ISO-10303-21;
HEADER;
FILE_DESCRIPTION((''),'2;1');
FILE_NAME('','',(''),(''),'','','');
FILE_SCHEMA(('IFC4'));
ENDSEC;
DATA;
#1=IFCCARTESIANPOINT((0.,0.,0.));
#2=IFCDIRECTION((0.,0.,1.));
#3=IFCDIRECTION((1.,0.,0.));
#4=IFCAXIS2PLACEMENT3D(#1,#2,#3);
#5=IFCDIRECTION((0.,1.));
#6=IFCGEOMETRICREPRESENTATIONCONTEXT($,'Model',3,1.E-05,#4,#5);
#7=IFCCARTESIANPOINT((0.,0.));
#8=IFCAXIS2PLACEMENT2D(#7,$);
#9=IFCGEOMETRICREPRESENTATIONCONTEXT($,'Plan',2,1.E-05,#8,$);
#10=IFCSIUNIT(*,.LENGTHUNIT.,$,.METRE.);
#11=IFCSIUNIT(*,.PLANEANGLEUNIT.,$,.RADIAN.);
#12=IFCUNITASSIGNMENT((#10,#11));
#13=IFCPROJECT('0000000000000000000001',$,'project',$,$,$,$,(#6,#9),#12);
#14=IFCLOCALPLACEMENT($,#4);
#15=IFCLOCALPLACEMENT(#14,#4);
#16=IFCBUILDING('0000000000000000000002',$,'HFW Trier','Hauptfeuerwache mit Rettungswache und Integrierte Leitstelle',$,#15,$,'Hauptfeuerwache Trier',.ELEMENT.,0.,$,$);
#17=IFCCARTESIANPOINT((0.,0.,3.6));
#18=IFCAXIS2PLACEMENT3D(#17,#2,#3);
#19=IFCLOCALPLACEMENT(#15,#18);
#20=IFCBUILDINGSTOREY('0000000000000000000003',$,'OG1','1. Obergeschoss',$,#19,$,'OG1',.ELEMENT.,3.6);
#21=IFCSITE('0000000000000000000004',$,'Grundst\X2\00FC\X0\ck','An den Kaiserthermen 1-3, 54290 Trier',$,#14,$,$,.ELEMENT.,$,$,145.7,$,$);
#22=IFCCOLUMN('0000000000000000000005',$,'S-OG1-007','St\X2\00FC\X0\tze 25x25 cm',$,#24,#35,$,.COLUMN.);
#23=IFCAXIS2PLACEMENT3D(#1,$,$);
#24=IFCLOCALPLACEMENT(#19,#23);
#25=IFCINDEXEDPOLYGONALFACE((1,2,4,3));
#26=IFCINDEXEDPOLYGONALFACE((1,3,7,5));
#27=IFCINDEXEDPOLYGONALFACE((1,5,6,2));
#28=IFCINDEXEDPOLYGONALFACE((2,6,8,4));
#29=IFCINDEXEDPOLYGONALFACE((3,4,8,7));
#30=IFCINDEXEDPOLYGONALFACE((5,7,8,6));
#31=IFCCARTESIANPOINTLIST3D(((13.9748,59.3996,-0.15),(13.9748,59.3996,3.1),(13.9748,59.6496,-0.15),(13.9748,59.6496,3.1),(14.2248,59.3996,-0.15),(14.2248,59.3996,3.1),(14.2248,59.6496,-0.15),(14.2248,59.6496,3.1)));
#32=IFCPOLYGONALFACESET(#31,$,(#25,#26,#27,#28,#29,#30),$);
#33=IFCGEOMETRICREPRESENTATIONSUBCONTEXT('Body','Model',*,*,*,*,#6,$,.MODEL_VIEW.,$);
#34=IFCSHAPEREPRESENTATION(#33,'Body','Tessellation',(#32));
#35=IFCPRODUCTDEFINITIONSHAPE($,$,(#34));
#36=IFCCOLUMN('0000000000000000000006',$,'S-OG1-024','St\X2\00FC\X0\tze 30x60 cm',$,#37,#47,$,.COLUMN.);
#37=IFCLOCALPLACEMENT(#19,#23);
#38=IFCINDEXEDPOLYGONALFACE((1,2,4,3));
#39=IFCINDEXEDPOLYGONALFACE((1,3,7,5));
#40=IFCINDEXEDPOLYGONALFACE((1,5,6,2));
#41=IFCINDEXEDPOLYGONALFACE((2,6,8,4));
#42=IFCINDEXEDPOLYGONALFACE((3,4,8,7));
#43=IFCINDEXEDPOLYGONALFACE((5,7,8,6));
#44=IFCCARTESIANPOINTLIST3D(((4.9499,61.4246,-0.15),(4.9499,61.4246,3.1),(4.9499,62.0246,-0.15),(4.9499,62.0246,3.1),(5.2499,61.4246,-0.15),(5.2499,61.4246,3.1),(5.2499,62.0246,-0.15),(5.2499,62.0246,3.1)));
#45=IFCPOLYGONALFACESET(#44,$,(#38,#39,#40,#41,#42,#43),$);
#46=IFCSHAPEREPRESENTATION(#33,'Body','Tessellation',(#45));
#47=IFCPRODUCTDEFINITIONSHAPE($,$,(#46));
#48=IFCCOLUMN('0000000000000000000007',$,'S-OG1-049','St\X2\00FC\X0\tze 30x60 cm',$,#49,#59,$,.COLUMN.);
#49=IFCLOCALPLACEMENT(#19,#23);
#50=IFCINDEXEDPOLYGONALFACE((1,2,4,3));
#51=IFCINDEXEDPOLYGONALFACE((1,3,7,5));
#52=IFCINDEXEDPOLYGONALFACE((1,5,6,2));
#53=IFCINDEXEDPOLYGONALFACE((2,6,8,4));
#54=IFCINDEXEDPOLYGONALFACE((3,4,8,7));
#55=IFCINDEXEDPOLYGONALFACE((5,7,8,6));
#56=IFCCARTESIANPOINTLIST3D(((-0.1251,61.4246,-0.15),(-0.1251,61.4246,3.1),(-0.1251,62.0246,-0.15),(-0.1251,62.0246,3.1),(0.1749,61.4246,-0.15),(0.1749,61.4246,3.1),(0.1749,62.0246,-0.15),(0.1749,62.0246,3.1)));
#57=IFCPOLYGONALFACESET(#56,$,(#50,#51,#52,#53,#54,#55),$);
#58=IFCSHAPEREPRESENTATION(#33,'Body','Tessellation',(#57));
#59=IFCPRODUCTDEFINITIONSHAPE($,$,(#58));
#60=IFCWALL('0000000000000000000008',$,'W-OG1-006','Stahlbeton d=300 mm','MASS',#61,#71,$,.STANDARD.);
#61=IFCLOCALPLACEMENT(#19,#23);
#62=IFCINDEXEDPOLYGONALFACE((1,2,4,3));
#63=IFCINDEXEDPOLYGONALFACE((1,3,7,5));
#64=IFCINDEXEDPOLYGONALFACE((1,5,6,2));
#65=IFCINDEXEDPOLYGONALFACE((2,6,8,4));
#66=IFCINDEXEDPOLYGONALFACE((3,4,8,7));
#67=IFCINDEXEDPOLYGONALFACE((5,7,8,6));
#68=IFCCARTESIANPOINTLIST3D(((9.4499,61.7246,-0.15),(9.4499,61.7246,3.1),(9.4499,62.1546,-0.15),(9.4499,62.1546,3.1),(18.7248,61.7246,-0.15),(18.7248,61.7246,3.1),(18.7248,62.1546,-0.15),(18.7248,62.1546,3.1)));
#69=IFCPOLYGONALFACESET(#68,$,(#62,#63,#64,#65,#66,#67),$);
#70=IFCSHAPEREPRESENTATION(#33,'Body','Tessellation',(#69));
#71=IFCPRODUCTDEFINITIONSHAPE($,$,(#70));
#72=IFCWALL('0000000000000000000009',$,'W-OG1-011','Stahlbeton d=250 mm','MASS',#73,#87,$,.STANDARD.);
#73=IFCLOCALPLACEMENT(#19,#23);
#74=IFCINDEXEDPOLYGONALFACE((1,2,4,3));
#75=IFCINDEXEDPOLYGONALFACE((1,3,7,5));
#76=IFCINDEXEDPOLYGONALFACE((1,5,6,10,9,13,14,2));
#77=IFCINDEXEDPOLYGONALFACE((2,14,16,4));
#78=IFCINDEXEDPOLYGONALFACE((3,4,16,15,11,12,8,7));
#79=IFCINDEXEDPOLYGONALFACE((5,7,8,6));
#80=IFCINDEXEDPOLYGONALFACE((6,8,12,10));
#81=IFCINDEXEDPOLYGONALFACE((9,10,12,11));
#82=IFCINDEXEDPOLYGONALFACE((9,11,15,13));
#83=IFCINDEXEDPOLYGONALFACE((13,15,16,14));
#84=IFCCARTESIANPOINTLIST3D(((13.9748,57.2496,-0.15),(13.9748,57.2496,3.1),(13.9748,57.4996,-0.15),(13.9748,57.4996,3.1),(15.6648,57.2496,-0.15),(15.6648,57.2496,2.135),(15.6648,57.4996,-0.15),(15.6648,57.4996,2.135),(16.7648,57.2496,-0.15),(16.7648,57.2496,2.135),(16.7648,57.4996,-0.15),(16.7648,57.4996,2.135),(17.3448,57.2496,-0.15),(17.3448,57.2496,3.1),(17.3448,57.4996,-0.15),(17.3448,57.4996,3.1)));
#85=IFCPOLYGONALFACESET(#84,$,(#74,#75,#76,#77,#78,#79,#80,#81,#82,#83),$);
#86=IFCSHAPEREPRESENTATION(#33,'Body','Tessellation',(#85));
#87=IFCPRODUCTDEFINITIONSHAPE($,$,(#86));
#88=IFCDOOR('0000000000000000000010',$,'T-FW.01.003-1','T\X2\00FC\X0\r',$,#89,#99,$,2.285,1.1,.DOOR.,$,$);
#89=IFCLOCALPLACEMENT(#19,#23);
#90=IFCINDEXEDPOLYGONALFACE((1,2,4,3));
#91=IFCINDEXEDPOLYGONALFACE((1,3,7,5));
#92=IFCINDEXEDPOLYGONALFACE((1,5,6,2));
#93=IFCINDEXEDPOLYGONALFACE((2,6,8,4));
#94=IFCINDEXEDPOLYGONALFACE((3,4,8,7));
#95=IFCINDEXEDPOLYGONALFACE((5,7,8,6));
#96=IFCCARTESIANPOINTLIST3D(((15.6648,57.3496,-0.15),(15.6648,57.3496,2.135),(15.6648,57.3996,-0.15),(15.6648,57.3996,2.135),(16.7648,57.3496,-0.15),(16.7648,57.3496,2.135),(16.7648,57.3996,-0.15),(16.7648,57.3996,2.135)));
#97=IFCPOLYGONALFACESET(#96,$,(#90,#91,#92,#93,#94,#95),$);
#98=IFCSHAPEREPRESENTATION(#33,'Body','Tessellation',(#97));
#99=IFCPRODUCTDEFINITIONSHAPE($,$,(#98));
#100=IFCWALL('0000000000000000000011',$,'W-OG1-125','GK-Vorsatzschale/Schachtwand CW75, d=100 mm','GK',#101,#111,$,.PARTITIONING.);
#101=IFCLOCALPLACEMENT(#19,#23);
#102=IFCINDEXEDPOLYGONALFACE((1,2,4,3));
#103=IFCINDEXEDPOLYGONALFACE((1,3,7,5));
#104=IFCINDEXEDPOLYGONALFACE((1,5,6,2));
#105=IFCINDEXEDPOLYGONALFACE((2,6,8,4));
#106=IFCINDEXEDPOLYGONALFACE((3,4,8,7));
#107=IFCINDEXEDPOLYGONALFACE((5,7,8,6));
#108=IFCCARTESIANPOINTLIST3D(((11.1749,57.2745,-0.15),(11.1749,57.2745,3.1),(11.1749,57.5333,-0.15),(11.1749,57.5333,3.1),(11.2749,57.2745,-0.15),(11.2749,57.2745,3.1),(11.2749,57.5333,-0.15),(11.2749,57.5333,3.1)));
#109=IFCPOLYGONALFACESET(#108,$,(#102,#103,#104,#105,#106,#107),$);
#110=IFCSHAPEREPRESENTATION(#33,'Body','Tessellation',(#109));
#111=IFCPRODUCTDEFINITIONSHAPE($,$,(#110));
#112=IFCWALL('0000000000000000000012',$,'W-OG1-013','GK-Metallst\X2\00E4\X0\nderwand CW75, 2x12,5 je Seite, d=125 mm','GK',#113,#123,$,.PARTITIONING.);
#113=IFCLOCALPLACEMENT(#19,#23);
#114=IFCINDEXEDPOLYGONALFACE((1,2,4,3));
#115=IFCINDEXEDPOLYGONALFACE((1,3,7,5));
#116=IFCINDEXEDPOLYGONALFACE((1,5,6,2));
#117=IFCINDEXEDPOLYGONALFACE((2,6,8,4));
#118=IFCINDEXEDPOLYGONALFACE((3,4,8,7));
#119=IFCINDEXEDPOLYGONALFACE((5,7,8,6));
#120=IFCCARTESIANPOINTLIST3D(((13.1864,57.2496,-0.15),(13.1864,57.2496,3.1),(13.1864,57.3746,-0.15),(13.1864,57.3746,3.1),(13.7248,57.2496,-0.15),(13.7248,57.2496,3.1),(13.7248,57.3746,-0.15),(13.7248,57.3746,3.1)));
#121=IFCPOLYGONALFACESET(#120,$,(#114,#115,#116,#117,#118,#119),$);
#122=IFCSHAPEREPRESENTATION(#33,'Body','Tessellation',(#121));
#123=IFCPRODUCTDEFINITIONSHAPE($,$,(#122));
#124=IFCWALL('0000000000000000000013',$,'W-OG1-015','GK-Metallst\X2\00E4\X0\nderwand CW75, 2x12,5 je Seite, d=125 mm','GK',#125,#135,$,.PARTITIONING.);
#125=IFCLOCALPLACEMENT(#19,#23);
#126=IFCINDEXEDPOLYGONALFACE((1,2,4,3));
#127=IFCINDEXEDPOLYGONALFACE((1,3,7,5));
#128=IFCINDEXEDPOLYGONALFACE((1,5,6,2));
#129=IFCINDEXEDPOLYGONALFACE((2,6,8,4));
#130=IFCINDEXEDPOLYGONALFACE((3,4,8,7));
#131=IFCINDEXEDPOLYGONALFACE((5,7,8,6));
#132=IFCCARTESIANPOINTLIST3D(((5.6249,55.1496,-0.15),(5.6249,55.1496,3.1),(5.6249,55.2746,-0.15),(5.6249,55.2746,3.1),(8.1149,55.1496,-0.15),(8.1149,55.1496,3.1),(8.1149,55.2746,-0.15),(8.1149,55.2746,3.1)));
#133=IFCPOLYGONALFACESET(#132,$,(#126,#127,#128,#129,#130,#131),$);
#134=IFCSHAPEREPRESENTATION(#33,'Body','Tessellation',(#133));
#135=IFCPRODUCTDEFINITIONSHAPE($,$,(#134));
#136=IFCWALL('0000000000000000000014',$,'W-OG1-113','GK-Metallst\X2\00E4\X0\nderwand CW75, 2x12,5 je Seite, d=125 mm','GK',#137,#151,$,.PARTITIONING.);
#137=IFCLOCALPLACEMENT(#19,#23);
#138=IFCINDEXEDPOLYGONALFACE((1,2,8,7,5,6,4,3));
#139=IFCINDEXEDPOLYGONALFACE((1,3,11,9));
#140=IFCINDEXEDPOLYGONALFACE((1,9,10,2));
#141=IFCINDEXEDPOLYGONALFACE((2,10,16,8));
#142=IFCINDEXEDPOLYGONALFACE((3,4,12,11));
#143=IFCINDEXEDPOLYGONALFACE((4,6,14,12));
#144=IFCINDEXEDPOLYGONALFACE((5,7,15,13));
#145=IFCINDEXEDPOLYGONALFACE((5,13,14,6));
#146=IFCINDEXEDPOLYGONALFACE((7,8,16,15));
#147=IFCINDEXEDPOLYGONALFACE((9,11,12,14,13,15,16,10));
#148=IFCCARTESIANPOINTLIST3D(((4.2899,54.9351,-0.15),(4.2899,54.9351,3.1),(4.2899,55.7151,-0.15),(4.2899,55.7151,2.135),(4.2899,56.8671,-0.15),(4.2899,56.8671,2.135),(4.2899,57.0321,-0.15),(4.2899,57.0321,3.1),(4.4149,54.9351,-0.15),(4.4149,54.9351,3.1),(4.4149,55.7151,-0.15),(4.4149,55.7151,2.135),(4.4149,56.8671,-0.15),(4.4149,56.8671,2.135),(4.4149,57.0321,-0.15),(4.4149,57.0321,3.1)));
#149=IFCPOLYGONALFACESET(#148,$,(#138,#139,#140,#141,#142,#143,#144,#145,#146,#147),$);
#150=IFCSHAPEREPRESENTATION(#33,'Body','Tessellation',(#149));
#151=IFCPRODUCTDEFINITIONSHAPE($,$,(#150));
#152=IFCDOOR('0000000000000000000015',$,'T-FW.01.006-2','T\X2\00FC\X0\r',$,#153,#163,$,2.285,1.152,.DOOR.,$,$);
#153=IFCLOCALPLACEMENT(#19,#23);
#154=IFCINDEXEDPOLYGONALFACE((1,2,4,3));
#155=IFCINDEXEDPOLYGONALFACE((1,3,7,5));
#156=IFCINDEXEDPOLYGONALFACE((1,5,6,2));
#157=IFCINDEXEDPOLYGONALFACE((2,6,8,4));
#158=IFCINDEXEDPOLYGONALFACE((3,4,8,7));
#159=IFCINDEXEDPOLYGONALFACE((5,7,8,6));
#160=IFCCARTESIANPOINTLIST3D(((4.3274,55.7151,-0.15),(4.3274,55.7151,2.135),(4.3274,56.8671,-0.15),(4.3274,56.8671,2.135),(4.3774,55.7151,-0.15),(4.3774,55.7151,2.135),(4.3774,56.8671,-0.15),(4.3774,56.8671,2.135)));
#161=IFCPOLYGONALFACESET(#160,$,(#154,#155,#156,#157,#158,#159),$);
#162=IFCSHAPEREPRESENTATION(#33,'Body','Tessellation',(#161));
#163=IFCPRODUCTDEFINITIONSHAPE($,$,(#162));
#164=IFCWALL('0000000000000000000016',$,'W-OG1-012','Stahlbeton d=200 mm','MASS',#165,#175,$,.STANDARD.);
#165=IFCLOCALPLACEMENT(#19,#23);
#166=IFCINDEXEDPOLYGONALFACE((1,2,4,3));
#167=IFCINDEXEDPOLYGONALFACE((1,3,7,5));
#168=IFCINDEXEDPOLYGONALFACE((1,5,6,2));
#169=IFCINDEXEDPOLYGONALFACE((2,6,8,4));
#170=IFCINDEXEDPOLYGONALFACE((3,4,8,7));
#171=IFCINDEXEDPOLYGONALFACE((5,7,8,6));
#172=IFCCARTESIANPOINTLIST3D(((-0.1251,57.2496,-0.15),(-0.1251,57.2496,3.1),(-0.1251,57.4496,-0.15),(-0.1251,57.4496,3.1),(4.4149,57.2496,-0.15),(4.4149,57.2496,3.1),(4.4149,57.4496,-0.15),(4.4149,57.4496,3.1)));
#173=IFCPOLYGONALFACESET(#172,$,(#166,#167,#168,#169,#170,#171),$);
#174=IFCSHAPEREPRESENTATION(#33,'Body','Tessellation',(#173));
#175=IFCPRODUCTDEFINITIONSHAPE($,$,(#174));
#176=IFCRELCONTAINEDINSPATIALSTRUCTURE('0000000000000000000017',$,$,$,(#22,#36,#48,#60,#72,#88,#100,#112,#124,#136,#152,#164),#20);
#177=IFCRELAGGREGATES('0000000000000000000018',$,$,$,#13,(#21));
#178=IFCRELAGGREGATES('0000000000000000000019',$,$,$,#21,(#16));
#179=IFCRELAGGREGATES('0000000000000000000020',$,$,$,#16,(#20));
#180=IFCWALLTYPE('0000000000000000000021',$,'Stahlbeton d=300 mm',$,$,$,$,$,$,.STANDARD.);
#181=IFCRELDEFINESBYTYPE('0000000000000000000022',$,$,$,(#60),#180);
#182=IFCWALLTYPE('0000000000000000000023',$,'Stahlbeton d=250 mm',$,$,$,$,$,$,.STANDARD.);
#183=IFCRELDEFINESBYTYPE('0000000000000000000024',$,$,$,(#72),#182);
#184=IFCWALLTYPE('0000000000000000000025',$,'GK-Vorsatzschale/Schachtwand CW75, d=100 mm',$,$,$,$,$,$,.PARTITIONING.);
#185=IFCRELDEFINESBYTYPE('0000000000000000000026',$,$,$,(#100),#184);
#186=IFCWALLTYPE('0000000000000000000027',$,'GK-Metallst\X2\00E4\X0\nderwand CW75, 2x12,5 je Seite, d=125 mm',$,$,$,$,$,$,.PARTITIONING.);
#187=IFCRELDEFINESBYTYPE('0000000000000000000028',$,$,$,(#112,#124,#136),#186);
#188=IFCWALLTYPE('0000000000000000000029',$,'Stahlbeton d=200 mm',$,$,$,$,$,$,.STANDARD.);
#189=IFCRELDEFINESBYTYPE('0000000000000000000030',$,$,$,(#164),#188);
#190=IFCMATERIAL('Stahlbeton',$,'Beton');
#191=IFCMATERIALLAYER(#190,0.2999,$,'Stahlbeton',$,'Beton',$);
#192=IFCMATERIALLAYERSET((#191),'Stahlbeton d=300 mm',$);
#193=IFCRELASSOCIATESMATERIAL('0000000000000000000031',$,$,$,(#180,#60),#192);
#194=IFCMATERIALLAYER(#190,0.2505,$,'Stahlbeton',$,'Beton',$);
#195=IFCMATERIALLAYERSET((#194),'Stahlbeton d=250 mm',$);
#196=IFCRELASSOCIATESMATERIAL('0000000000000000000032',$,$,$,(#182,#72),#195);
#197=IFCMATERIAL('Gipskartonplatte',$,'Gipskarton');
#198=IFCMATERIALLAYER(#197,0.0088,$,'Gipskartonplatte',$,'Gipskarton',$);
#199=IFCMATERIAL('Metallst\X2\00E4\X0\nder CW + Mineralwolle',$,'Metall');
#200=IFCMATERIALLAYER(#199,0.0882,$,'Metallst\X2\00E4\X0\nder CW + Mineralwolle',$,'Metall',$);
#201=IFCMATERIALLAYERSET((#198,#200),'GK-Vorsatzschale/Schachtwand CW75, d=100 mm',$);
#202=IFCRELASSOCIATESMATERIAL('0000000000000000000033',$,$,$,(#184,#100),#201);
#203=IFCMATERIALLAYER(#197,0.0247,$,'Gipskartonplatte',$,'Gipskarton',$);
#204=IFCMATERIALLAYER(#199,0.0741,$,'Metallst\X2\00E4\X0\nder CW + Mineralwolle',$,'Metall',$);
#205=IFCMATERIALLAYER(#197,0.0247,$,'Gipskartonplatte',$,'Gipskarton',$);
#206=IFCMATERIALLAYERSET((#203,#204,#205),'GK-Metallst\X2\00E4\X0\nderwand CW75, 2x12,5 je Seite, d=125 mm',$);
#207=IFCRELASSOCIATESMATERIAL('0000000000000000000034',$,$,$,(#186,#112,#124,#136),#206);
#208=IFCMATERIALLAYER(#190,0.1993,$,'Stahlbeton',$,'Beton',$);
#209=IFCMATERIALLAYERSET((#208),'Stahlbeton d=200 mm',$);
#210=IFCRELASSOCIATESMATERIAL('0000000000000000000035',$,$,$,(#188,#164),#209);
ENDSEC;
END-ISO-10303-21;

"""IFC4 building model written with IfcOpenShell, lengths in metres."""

from ifc_helpers import new_model, si_unit, direction, frame, frame_2d, origin_with_axes, origin_2d, place, context, subcontext, project, spatial, rectangle, extrude, material, layer, layer_set, layer_usage, type_object, element, fill, save


model = new_model("IFC4")

# Units and contexts
model_context = context("Model", 3, precision=1e-05, world=origin_with_axes(), true_north=direction((0.0, 1.0)))
plan_context = context("Plan", 2, precision=1e-05, world=origin_2d())
body_context = subcontext(model_context, "Body", "Model", "MODEL_VIEW")
ifc_project = project(units=[si_unit("LENGTHUNIT", "METRE"), si_unit("PLANEANGLEUNIT", "RADIAN")], contexts=[model_context, plan_context])

# Site, building, storey
site_placement = place(None, origin_with_axes())
site = spatial("IfcSite", under=ifc_project, at=site_placement, Name="Grundstück", Description="An den Kaiserthermen 1-3, 54290 Trier", CompositionType="ELEMENT", RefElevation=145.7)
building_placement = place(site_placement, origin_with_axes())
building = spatial("IfcBuilding", under=site, at=building_placement, Name="HFW Trier", Description="Hauptfeuerwache mit Rettungswache und Integrierte Leitstelle", LongName="Hauptfeuerwache Trier", CompositionType="ELEMENT", ElevationOfRefHeight=0.0)
storey_placement = place(building_placement, frame((0.0, 0.0, 3.6), z_axis=(0.0, 0.0, 1.0), x_axis=(1.0, 0.0, 0.0)))
storey = spatial("IfcBuildingStorey", under=building, at=storey_placement, Name="OG1", Description="1. Obergeschoss", LongName="OG1", CompositionType="ELEMENT", Elevation=3.6)

# Columns
column_placement = place(storey_placement, frame((13.9748, 59.5246, -0.15), z_axis=(0.0, 0.0, 1.0), x_axis=(1.0, 0.0, 0.0)))
element("IfcColumn", 1, at=column_placement, inside=storey, Name="S-OG1-007", Description="Stütze 25x25 cm", PredefinedType="COLUMN", context=body_context, shape_type="SweptSolid", body=[
    extrude(rectangle(XDim=0.25, YDim=0.25, at=frame_2d((0.125, 0.0))), origin_with_axes(), (0.0, 0.0, 1.0), 3.25),
])
for number, where, z_axis, x_axis, name in (
    (2, (4.9499, 61.7246, -0.15), (0.0, 0.0, 1.0), (1.0, 0.0, 0.0), "S-OG1-024"),
    (3, (-0.1251, 61.7246, -0.15), (0.0, 0.0, 1.0), (1.0, 0.0, 0.0), "S-OG1-049"),
):
    element("IfcColumn", number, at=place(storey_placement, frame(where, z_axis=z_axis, x_axis=x_axis)), inside=storey, Name=name, Description="Stütze 30x60 cm", PredefinedType="COLUMN", context=body_context, shape_type="SweptSolid", body=[
        extrude(rectangle(XDim=0.3, YDim=0.6, at=frame_2d((0.15, 0.0))), origin_with_axes(), (0.0, 0.0, 1.0), 3.25),
    ])

# Wall
ifc_material_1 = material(Name="Stahlbeton", Category="Beton")
ifc_layer_1 = layer(ifc_material_1, 0.2999, Name="Stahlbeton", Category="Beton")
ifc_layer_set_1 = layer_set([ifc_layer_1], Name="Stahlbeton d=300 mm")
ifc_layer_usage_1 = layer_usage(ifc_layer_set_1, "AXIS2", "POSITIVE", -0.215)
wall_type_1 = type_object("IfcWallType", Name="Stahlbeton d=300 mm", PredefinedType="STANDARD", material=ifc_layer_set_1)
wall_1_placement = place(storey_placement, frame((9.4499, 61.9396, -0.15), z_axis=(0.0, 0.0, 1.0), x_axis=(1.0, 0.0, 0.0)))
element("IfcWall", 4, at=wall_1_placement, inside=storey, type_object=wall_type_1, material=ifc_layer_usage_1, Name="W-OG1-006", Description="Stahlbeton d=300 mm", ObjectType="MASS", PredefinedType="STANDARD", context=body_context, shape_type="SweptSolid", body=[
    extrude(rectangle(XDim=9.2749, YDim=0.43, at=frame_2d((4.6374, 0.0))), origin_with_axes(), (0.0, 0.0, 1.0), 3.25),
])

# Wall, opening, door
ifc_layer_2 = layer(ifc_material_1, 0.2505, Name="Stahlbeton", Category="Beton")
ifc_layer_set_2 = layer_set([ifc_layer_2], Name="Stahlbeton d=250 mm")
ifc_layer_usage_2 = layer_usage(ifc_layer_set_2, "AXIS2", "POSITIVE", -0.125)
wall_type_2 = type_object("IfcWallType", Name="Stahlbeton d=250 mm", PredefinedType="STANDARD", material=ifc_layer_set_2)
wall_2_placement = place(storey_placement, frame((13.9748, 57.3746, -0.15), z_axis=(0.0, 0.0, 1.0), x_axis=(1.0, 0.0, 0.0)))
wall_2 = element("IfcWall", 5, at=wall_2_placement, inside=storey, type_object=wall_type_2, material=ifc_layer_usage_2, Name="W-OG1-011", Description="Stahlbeton d=250 mm", ObjectType="MASS", PredefinedType="STANDARD", context=body_context, shape_type="SweptSolid", body=[
    extrude(rectangle(XDim=3.37, YDim=0.25, at=frame_2d((1.685, 0.0))), origin_with_axes(), (0.0, 0.0, 1.0), 3.25),
])
opening_1_placement = place(wall_2_placement, frame((1.69, 0.0, 0.0), z_axis=(0.0, 0.0, 1.0), x_axis=(1.0, 0.0, 0.0)))
opening_1 = element("IfcOpeningElement", 6, at=opening_1_placement, cuts=wall_2, PredefinedType="OPENING", context=body_context, shape_type="SweptSolid", body=[
    extrude(rectangle(XDim=1.1, YDim=0.35, at=frame_2d((0.55, 0.0))), origin_with_axes(), (0.0, 0.0, 1.0), 2.285),
])
door_1_placement = place(wall_2_placement, frame((1.69, 0.0, 0.0), z_axis=(0.0, 0.0, 1.0), x_axis=(1.0, 0.0, 0.0)))
door_1 = element("IfcDoor", 7, at=door_1_placement, inside=storey, Name="T-FW.01.003-1", Description="Tür", OverallHeight=2.285, OverallWidth=1.1, PredefinedType="DOOR", context=body_context, shape_type="SweptSolid", body=[
    extrude(rectangle(XDim=1.1, YDim=0.05, at=frame_2d((0.55, 0.0))), origin_with_axes(), (0.0, 0.0, 1.0), 2.285),
])
fill(opening_1, door_1)

# Walls
ifc_material_2 = material(Name="Gipskartonplatte", Category="Gipskarton")
ifc_layer_3 = layer(ifc_material_2, 0.0088, Name="Gipskartonplatte", Category="Gipskarton")
ifc_material_3 = material(Name="Metallständer CW + Mineralwolle", Category="Metall")
ifc_layer_4 = layer(ifc_material_3, 0.0882, Name="Metallständer CW + Mineralwolle", Category="Metall")
ifc_layer_set_3 = layer_set([ifc_layer_3, ifc_layer_4], Name="GK-Vorsatzschale/Schachtwand CW75, d=100 mm")
ifc_layer_usage_3 = layer_usage(ifc_layer_set_3, "AXIS2", "POSITIVE", -0.05)
wall_type_3 = type_object("IfcWallType", Name="GK-Vorsatzschale/Schachtwand CW75, d=100 mm", PredefinedType="PARTITIONING", material=ifc_layer_set_3)
wall_3_placement = place(storey_placement, frame((11.2249, 57.5333, -0.15), z_axis=(0.0, 0.0, 1.0), x_axis=(0.0, -1.0, 0.0)))
element("IfcWall", 8, at=wall_3_placement, inside=storey, type_object=wall_type_3, material=ifc_layer_usage_3, Name="W-OG1-125", Description="GK-Vorsatzschale/Schachtwand CW75, d=100 mm", ObjectType="GK", PredefinedType="PARTITIONING", context=body_context, shape_type="SweptSolid", body=[
    extrude(rectangle(XDim=0.2588, YDim=0.1, at=frame_2d((0.1294, 0.0))), origin_with_axes(), (0.0, 0.0, 1.0), 3.25),
])
ifc_layer_5 = layer(ifc_material_2, 0.0247, Name="Gipskartonplatte", Category="Gipskarton")
ifc_layer_6 = layer(ifc_material_3, 0.0741, Name="Metallständer CW + Mineralwolle", Category="Metall")
ifc_layer_7 = layer(ifc_material_2, 0.0247, Name="Gipskartonplatte", Category="Gipskarton")
ifc_layer_set_4 = layer_set([ifc_layer_5, ifc_layer_6, ifc_layer_7], Name="GK-Metallständerwand CW75, 2x12,5 je Seite, d=125 mm")
ifc_layer_usage_4 = layer_usage(ifc_layer_set_4, "AXIS2", "POSITIVE", -0.0625)
wall_type_4 = type_object("IfcWallType", Name="GK-Metallständerwand CW75, 2x12,5 je Seite, d=125 mm", PredefinedType="PARTITIONING", material=ifc_layer_set_4)
wall_4_placement = place(storey_placement, frame((13.1864, 57.3121, -0.15), z_axis=(0.0, 0.0, 1.0), x_axis=(1.0, 0.0, 0.0)))
element("IfcWall", 9, at=wall_4_placement, inside=storey, type_object=wall_type_4, material=ifc_layer_usage_4, Name="W-OG1-013", Description="GK-Metallständerwand CW75, 2x12,5 je Seite, d=125 mm", ObjectType="GK", PredefinedType="PARTITIONING", context=body_context, shape_type="SweptSolid", body=[
    extrude(rectangle(XDim=0.5384, YDim=0.125, at=frame_2d((0.2692, 0.0))), origin_with_axes(), (0.0, 0.0, 1.0), 3.25),
])
ifc_layer_usage_5 = layer_usage(ifc_layer_set_4, "AXIS2", "POSITIVE", -0.0625)
wall_5_placement = place(storey_placement, frame((5.6249, 55.2121, -0.15), z_axis=(0.0, 0.0, 1.0), x_axis=(1.0, 0.0, 0.0)))
element("IfcWall", 10, at=wall_5_placement, inside=storey, type_object=wall_type_4, material=ifc_layer_usage_5, Name="W-OG1-015", Description="GK-Metallständerwand CW75, 2x12,5 je Seite, d=125 mm", ObjectType="GK", PredefinedType="PARTITIONING", context=body_context, shape_type="SweptSolid", body=[
    extrude(rectangle(XDim=2.49, YDim=0.125, at=frame_2d((1.245, 0.0))), origin_with_axes(), (0.0, 0.0, 1.0), 3.25),
])

# Wall, opening, door
ifc_layer_usage_6 = layer_usage(ifc_layer_set_4, "AXIS2", "POSITIVE", -0.0625)
wall_6_placement = place(storey_placement, frame((4.3524, 57.0321, -0.15), z_axis=(0.0, 0.0, 1.0), x_axis=(0.0, -1.0, 0.0)))
wall_6 = element("IfcWall", 11, at=wall_6_placement, inside=storey, type_object=wall_type_4, material=ifc_layer_usage_6, Name="W-OG1-113", Description="GK-Metallständerwand CW75, 2x12,5 je Seite, d=125 mm", ObjectType="GK", PredefinedType="PARTITIONING", context=body_context, shape_type="SweptSolid", body=[
    extrude(rectangle(XDim=2.097, YDim=0.125, at=frame_2d((1.0485, 0.0))), origin_with_axes(), (0.0, 0.0, 1.0), 3.25),
])
opening_2_placement = place(wall_6_placement, frame((0.165, 0.0, 0.0), z_axis=(0.0, 0.0, 1.0), x_axis=(1.0, 0.0, 0.0)))
opening_2 = element("IfcOpeningElement", 12, at=opening_2_placement, cuts=wall_6, PredefinedType="OPENING", context=body_context, shape_type="SweptSolid", body=[
    extrude(rectangle(XDim=1.152, YDim=0.225, at=frame_2d((0.576, 0.0))), origin_with_axes(), (0.0, 0.0, 1.0), 2.285),
])
door_2_placement = place(wall_6_placement, frame((0.165, 0.0, 0.0), z_axis=(0.0, 0.0, 1.0), x_axis=(1.0, 0.0, 0.0)))
door_2 = element("IfcDoor", 13, at=door_2_placement, inside=storey, Name="T-FW.01.006-2", Description="Tür", OverallHeight=2.285, OverallWidth=1.152, PredefinedType="DOOR", context=body_context, shape_type="SweptSolid", body=[
    extrude(rectangle(XDim=1.152, YDim=0.05, at=frame_2d((0.576, 0.0))), origin_with_axes(), (0.0, 0.0, 1.0), 2.285),
])
fill(opening_2, door_2)

# Wall
ifc_layer_8 = layer(ifc_material_1, 0.1993, Name="Stahlbeton", Category="Beton")
ifc_layer_set_5 = layer_set([ifc_layer_8], Name="Stahlbeton d=200 mm")
ifc_layer_usage_7 = layer_usage(ifc_layer_set_5, "AXIS2", "POSITIVE", -0.1)
wall_type_5 = type_object("IfcWallType", Name="Stahlbeton d=200 mm", PredefinedType="STANDARD", material=ifc_layer_set_5)
wall_7_placement = place(storey_placement, frame((-0.1251, 57.3496, -0.15), z_axis=(0.0, 0.0, 1.0), x_axis=(1.0, 0.0, 0.0)))
element("IfcWall", 14, at=wall_7_placement, inside=storey, type_object=wall_type_5, material=ifc_layer_usage_7, Name="W-OG1-012", Description="Stahlbeton d=200 mm", ObjectType="MASS", PredefinedType="STANDARD", context=body_context, shape_type="SweptSolid", body=[
    extrude(rectangle(XDim=4.54, YDim=0.2, at=frame_2d((2.27, 0.0))), origin_with_axes(), (0.0, 0.0, 1.0), 3.25),
])

save(model, "model.ifc")
